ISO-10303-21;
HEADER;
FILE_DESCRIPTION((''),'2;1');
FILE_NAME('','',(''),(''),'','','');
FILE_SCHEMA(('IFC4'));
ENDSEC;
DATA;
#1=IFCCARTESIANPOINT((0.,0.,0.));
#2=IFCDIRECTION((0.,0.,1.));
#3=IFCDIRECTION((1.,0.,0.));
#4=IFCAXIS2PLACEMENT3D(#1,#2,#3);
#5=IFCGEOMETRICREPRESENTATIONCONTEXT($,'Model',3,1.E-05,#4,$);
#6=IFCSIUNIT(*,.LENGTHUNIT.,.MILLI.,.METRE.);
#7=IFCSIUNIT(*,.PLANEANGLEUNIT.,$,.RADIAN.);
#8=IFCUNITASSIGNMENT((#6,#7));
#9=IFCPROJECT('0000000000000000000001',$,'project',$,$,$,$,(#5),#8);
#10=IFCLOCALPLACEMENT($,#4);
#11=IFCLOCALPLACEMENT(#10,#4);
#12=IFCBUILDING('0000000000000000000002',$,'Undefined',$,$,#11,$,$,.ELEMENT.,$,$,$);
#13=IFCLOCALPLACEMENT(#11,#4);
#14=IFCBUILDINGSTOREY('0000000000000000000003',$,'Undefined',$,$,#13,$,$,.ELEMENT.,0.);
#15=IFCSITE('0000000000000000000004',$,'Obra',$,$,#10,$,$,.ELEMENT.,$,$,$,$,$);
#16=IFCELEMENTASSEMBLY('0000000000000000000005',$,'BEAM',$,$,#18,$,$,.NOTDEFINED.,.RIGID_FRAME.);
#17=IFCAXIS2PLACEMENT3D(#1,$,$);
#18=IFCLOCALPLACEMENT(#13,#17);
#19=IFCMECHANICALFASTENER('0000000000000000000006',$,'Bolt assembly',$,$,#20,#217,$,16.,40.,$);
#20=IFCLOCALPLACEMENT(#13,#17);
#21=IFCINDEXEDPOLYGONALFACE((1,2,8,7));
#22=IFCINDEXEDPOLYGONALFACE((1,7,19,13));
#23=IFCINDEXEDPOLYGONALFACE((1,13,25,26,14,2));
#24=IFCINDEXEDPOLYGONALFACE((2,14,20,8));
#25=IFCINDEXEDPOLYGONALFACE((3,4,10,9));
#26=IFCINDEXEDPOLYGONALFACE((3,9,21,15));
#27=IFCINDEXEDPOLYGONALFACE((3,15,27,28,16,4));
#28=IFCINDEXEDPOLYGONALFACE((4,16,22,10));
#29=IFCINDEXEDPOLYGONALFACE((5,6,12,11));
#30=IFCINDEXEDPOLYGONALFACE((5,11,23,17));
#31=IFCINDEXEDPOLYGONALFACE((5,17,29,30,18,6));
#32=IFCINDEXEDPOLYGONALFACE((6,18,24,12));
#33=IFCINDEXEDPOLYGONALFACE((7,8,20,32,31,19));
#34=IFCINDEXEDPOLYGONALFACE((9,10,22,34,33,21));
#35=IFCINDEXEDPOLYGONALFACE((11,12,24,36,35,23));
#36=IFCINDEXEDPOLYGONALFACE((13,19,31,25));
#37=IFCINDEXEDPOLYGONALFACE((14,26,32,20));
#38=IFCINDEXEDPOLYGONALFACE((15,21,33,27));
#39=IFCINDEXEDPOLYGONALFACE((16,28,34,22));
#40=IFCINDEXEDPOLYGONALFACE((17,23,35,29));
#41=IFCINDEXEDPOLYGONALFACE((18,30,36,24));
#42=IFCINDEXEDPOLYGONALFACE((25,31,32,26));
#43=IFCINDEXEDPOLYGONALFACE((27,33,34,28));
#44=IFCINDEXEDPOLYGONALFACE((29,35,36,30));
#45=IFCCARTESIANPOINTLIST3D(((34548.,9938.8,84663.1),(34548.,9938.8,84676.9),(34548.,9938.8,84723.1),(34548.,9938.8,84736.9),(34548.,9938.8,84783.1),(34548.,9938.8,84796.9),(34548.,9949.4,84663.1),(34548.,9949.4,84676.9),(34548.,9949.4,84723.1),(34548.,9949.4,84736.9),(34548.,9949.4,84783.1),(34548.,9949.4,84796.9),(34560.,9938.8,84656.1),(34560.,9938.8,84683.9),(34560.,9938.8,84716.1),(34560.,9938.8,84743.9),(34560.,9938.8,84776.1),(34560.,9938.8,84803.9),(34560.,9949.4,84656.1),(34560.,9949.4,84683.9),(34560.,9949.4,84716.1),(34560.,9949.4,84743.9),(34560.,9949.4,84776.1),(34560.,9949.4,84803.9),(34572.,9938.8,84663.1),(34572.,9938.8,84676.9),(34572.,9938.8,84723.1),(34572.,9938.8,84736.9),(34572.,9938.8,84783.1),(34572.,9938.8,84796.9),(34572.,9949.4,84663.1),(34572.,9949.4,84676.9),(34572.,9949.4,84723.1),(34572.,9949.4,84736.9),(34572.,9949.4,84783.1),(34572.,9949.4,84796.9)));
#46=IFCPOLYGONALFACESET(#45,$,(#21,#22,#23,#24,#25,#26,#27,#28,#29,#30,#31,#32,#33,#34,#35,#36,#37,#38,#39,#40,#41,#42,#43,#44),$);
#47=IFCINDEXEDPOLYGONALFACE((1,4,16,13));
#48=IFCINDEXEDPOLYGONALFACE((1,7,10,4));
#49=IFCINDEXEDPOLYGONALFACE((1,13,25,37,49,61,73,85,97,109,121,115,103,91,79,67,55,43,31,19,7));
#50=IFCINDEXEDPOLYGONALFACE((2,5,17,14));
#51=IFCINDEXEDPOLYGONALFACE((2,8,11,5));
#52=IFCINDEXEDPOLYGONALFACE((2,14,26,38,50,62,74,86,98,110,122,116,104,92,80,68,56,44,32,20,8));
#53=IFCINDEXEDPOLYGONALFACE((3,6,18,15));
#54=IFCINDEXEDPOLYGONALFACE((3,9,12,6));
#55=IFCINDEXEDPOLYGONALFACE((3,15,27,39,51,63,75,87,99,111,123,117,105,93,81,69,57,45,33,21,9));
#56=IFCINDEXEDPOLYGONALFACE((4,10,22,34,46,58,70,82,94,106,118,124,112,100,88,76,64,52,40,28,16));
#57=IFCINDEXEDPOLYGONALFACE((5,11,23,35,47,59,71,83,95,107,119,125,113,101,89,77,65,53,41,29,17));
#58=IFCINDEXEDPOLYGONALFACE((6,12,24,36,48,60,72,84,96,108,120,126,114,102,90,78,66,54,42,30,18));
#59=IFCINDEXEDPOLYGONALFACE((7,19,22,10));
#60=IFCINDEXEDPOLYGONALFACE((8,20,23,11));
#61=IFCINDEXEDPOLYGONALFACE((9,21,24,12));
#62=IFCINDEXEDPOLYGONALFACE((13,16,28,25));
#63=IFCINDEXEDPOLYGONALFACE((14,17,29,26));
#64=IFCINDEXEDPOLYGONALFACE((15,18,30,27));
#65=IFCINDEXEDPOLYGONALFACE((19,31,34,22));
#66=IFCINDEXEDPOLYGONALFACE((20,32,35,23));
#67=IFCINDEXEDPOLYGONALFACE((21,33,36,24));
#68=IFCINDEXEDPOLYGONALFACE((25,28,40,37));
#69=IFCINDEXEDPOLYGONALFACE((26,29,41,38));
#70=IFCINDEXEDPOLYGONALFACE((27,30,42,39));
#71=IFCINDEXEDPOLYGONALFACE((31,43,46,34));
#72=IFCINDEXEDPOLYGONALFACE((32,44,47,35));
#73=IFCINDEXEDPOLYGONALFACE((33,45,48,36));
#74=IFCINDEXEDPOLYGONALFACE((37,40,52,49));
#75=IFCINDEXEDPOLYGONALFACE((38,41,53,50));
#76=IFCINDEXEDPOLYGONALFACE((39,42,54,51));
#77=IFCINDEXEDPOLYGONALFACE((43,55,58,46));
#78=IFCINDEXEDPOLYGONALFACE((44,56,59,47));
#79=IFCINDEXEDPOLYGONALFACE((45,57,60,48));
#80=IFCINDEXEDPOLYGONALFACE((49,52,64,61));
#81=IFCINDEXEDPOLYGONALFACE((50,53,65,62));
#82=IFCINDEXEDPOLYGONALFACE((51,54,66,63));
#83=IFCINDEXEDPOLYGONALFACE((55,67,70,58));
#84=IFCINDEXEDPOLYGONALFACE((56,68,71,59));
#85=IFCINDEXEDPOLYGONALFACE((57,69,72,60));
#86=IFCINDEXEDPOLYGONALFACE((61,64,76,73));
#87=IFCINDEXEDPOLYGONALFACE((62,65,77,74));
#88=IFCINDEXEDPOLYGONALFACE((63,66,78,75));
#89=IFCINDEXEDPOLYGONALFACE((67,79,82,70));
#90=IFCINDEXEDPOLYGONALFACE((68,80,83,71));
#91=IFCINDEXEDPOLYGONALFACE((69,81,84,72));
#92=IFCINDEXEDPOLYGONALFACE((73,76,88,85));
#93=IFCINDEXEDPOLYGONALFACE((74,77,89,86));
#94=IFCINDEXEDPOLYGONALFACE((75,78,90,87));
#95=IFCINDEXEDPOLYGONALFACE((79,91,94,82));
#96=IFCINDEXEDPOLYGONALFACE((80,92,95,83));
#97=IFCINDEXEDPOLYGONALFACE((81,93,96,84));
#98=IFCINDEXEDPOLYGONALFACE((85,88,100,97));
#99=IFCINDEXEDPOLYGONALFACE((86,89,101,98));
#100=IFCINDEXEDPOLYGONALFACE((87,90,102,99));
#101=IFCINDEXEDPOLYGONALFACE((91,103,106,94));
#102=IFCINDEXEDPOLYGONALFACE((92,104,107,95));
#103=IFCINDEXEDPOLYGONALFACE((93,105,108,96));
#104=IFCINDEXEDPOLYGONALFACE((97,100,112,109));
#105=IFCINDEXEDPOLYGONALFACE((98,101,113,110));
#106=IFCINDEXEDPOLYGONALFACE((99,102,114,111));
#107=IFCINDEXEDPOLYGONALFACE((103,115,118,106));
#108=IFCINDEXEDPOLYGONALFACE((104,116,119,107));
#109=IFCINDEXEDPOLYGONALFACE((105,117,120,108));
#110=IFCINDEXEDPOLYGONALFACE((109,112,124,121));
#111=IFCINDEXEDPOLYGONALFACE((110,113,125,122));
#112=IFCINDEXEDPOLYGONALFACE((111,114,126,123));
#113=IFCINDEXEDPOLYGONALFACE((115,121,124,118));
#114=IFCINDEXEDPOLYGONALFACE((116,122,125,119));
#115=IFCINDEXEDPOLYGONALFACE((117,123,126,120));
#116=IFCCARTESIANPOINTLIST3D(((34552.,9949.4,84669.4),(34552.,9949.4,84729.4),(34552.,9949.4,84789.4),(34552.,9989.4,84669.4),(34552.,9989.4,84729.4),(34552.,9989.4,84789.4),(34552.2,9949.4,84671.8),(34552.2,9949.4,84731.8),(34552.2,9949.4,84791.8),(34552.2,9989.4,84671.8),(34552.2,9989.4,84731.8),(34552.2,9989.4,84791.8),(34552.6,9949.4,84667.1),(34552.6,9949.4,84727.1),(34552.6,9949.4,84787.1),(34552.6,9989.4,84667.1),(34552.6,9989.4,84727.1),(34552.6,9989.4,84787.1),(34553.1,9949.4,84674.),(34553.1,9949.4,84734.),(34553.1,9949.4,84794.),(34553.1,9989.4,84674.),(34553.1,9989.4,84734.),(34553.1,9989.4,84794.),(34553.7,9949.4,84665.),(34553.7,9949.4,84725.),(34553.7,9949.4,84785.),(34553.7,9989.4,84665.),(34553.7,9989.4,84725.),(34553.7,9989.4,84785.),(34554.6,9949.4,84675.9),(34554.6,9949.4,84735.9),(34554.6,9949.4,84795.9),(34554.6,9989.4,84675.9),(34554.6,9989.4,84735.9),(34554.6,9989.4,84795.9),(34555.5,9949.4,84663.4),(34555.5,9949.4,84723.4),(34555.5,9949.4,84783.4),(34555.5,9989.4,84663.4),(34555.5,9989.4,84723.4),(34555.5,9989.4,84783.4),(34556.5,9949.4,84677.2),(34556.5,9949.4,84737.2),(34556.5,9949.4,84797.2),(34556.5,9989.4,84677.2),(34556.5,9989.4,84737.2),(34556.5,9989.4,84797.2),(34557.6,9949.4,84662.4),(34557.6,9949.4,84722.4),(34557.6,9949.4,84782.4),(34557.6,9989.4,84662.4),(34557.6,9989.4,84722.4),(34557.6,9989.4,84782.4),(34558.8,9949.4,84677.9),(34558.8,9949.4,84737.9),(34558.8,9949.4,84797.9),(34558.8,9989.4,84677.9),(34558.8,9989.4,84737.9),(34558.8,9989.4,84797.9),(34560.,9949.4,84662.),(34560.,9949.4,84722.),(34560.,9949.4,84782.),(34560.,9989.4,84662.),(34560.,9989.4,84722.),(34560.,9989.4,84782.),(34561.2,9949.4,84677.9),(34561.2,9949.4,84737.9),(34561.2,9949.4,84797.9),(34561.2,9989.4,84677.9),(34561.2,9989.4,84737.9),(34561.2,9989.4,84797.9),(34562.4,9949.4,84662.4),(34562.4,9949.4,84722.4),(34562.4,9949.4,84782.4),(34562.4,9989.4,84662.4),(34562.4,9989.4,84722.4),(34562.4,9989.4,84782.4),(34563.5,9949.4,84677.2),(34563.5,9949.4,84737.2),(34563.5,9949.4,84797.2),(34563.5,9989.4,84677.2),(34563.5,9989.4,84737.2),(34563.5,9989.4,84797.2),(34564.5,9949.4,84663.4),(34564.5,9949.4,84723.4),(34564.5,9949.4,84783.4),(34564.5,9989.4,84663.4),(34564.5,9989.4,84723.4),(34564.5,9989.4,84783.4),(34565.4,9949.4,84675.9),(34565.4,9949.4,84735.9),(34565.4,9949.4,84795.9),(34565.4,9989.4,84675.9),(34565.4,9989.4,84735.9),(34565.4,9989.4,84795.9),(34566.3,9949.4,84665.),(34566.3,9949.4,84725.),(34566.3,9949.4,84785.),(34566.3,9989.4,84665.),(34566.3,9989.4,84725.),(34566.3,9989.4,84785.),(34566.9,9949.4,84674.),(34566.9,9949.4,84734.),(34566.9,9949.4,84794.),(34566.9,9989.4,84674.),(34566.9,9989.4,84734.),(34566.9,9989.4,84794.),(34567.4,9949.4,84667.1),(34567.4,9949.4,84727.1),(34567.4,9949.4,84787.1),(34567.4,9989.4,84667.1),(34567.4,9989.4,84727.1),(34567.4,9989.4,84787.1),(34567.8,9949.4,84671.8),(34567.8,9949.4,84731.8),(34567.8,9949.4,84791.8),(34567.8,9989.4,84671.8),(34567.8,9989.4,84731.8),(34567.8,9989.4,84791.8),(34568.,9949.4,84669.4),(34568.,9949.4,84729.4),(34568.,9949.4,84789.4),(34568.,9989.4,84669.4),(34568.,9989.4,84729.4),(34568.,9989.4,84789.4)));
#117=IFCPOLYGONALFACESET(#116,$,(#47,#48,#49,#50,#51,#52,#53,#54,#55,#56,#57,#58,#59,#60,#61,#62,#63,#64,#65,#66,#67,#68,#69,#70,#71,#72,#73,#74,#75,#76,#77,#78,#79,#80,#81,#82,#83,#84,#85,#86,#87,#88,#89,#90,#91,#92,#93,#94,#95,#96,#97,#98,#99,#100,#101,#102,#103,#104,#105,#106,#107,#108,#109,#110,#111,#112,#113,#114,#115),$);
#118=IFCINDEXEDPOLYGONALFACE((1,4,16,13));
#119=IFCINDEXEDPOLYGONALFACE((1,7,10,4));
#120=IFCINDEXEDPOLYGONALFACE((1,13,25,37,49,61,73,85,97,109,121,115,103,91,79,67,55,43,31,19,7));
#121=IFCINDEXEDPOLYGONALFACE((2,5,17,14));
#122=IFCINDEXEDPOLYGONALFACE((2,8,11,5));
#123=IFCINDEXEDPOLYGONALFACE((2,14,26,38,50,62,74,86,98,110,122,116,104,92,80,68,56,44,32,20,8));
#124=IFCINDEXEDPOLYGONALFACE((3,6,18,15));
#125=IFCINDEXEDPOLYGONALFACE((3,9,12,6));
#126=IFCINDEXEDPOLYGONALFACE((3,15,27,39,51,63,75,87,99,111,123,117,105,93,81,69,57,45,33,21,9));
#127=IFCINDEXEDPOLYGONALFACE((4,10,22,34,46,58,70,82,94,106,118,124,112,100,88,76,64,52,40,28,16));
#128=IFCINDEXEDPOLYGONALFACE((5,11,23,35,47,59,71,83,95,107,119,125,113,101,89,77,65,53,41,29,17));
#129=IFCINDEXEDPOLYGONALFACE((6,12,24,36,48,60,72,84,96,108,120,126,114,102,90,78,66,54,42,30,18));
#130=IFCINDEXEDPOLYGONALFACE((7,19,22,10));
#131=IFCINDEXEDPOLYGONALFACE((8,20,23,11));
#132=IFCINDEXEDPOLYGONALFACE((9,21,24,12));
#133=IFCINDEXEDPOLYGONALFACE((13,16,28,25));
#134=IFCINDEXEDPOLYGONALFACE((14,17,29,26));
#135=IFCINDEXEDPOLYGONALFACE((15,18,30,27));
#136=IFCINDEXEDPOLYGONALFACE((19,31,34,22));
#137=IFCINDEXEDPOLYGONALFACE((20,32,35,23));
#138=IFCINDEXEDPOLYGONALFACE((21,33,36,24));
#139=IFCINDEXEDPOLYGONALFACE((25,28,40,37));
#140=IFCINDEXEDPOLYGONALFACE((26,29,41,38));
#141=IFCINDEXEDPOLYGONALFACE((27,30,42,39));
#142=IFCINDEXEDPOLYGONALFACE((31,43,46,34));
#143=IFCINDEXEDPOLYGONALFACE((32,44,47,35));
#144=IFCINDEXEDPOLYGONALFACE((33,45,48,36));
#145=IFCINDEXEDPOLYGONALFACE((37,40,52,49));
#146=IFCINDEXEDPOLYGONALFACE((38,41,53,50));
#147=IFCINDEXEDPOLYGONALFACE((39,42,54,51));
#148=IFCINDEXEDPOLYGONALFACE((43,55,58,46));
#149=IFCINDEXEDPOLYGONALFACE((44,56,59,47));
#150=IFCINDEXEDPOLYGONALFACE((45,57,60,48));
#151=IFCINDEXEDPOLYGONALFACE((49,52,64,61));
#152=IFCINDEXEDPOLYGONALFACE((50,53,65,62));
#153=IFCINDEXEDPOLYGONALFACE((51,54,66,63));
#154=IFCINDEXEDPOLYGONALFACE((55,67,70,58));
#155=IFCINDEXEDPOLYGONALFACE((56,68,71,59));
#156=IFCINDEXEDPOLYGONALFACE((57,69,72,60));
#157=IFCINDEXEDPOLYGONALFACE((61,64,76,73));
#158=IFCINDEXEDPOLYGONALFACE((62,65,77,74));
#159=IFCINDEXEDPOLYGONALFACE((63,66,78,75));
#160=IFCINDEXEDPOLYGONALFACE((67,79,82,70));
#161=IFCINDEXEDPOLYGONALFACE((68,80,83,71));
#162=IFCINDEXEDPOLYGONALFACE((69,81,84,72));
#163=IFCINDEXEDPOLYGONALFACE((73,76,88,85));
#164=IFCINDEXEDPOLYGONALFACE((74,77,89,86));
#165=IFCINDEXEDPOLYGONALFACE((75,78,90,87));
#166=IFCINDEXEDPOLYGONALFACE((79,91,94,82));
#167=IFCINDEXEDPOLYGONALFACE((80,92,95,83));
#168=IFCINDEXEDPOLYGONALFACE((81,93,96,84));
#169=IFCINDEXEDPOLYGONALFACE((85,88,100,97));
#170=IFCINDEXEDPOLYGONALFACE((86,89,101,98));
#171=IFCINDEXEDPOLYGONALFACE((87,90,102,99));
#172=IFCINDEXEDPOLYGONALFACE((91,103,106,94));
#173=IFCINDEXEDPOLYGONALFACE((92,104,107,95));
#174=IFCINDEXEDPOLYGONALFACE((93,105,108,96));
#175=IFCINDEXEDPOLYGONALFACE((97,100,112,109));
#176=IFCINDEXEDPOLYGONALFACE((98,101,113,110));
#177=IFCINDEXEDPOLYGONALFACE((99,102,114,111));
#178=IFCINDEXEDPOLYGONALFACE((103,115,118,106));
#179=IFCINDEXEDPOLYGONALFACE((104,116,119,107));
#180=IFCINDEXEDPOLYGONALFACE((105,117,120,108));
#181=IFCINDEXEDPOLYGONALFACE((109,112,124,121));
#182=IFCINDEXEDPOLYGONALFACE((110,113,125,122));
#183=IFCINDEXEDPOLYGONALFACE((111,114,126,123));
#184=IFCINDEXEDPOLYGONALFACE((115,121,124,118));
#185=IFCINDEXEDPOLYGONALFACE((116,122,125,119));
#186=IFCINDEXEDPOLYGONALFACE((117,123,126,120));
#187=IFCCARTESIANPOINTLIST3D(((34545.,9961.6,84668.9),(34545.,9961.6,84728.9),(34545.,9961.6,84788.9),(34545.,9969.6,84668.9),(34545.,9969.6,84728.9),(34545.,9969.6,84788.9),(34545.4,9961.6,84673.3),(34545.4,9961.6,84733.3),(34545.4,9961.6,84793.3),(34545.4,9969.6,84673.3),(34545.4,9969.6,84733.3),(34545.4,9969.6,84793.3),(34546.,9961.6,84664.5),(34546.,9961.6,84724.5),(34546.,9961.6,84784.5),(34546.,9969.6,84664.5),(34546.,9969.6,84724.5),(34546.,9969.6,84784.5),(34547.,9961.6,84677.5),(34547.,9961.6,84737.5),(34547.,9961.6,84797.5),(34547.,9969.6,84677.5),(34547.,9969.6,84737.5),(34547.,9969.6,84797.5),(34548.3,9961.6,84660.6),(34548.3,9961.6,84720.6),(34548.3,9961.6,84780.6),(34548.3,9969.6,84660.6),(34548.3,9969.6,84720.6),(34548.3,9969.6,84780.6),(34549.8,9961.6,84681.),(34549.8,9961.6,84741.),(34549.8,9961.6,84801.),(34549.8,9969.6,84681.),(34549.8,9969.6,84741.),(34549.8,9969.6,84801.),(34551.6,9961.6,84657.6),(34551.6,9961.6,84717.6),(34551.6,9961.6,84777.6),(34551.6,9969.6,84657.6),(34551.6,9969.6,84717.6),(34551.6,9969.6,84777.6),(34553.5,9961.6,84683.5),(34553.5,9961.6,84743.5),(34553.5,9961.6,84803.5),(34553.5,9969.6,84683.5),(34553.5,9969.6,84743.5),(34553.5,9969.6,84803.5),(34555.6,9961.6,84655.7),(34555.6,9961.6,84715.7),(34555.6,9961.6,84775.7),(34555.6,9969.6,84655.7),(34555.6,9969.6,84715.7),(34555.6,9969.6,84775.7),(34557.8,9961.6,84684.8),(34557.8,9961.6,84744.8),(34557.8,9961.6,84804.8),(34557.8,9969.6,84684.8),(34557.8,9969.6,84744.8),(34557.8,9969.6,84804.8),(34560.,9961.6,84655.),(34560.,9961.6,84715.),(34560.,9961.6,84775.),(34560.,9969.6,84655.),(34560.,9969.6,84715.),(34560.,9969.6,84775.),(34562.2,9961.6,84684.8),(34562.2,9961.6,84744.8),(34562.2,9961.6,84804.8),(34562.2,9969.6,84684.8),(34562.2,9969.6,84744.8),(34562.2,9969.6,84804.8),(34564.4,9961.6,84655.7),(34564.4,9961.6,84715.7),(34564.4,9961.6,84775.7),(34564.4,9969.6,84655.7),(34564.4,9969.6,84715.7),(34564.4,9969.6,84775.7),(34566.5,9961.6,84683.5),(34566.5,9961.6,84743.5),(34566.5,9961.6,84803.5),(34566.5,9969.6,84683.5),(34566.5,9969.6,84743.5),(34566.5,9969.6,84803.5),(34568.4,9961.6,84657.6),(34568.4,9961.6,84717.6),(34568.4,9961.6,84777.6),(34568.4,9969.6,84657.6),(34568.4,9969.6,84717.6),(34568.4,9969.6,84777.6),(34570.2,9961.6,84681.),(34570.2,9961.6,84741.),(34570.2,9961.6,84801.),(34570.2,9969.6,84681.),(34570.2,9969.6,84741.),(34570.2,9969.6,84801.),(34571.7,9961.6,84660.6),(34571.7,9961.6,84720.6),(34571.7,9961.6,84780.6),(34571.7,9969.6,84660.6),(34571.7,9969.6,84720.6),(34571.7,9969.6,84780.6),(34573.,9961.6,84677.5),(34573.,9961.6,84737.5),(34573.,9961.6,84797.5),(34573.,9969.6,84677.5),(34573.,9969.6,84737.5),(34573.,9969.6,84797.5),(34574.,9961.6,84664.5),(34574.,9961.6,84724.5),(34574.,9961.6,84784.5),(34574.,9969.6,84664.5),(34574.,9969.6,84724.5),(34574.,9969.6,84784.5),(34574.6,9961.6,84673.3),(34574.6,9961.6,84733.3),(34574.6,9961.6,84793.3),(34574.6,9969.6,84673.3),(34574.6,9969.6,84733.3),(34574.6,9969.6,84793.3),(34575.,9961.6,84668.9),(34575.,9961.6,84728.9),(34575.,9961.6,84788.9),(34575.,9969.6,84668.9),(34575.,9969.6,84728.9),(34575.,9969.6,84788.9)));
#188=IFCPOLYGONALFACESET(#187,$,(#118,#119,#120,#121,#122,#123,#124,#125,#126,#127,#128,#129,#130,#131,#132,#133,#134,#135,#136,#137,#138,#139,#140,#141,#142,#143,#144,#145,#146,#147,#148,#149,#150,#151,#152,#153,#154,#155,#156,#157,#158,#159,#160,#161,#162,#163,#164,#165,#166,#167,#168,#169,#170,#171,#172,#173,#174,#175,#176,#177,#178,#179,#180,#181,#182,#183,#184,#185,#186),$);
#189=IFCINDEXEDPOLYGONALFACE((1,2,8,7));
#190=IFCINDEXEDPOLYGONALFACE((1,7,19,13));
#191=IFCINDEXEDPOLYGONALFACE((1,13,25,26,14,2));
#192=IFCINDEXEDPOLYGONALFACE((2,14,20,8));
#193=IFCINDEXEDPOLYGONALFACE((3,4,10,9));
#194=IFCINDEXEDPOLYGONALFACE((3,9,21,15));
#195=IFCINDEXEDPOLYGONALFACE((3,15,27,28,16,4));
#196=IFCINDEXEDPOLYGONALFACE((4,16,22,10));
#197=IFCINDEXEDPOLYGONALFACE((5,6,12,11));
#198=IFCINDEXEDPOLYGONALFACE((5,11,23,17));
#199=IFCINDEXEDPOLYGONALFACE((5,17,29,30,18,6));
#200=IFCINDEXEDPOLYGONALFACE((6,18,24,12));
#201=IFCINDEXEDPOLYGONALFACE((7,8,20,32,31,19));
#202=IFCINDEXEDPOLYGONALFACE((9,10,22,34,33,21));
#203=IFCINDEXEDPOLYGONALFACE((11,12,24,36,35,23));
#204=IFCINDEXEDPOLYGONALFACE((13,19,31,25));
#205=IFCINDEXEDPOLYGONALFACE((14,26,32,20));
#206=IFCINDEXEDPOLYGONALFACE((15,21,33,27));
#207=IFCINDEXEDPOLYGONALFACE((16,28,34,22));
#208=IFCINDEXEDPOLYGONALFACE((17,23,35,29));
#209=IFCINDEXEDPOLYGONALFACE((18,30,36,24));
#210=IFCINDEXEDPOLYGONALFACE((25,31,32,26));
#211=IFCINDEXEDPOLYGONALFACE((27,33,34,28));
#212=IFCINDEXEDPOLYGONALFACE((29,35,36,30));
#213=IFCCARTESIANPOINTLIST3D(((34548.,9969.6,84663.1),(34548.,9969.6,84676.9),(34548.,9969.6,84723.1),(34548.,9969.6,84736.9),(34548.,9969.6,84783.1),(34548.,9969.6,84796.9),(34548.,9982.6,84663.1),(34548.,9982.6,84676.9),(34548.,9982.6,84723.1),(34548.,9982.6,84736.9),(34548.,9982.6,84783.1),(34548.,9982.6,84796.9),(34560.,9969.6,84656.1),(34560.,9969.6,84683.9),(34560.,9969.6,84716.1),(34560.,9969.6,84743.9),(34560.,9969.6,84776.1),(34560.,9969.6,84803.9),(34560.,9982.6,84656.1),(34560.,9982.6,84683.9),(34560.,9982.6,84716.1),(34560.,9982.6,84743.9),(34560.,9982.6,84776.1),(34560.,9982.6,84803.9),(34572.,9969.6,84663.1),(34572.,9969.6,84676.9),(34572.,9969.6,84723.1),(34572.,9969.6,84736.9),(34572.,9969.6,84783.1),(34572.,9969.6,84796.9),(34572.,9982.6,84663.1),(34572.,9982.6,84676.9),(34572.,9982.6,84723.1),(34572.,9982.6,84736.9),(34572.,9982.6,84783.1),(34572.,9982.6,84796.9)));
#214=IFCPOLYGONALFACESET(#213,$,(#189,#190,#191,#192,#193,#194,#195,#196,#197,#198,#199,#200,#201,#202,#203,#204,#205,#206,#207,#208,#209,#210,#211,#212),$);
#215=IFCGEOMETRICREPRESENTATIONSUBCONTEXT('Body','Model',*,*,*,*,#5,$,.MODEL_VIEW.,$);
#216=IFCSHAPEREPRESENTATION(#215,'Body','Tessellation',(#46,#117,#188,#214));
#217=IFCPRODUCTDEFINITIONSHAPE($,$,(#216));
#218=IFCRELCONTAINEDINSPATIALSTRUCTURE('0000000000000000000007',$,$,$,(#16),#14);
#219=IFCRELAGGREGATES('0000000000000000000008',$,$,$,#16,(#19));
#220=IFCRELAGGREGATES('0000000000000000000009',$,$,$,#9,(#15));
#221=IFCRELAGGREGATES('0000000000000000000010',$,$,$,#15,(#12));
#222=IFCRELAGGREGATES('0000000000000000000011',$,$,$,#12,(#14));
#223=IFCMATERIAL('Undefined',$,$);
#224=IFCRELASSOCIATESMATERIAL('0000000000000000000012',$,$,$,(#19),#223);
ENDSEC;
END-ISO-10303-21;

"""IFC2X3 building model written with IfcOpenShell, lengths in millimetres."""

from ifc_helpers import new_model, si_unit, frame, origin_with_axes, origin_2d_with_axis, place, context, subcontext, project, spatial, polyline, circle, outline, extrude, source, transform, mapped, material, element, aggregate, save


model = new_model("IFC2X3")

# Units and contexts
model_context = context("Model", 3, precision=1e-05, world=origin_with_axes())
body_context = subcontext(model_context, "Body", "Model", "MODEL_VIEW")
ifc_project = project(units=[si_unit("LENGTHUNIT", "METRE", prefix="MILLI"), si_unit("PLANEANGLEUNIT", "RADIAN")], contexts=[model_context])

# Site, building, storey
site_placement = place(None, origin_with_axes())
site = spatial("IfcSite", under=ifc_project, at=site_placement, Name="Obra", CompositionType="ELEMENT")
building_placement = place(site_placement, origin_with_axes())
building = spatial("IfcBuilding", under=site, at=building_placement, Name="Undefined", CompositionType="ELEMENT")
storey_placement = place(building_placement, origin_with_axes())
storey = spatial("IfcBuildingStorey", under=building, at=storey_placement, Name="Undefined", CompositionType="ELEMENT", Elevation=0.0)

# Shared definitions
ifc_material_1 = material(Name="Undefined")

# Element assembly, mechanical fastener
assembly_1_placement = place(storey_placement, origin_with_axes())
assembly_1 = element("IfcElementAssembly", 1, at=assembly_1_placement, inside=storey, Name="BEAM", AssemblyPlace="NOTDEFINED", PredefinedType="RIGID_FRAME")
shared_shape_1 = source(origin_with_axes(), body_context, "Body", "SweptSolid", [
    extrude(outline(polyline([(13.9, 0.0), (6.9, 12.0), (-6.9, 12.0), (-13.9, 0.0), (-6.9, -12.0), (6.9, -12.0), (13.9, 0.0)])), frame((0.0, -19.7, 0.0), z_axis=(0.0, 1.0, 0.0), x_axis=(1.0, 0.0, 0.0)), (0.0, 0.0, 1.0), 10.6),
    extrude(circle(Radius=8.0, at=origin_2d_with_axis()), frame((0.0, -9.1, 0.0), z_axis=(0.0, 1.0, 0.0), x_axis=(1.0, 0.0, 0.0)), (0.0, 0.0, 1.0), 40.0),
    extrude(circle(Radius=15.0, at=origin_2d_with_axis()), frame((0.0, 3.1, 0.0), z_axis=(0.0, 1.0, 0.0), x_axis=(1.0, 0.0, 0.0)), (0.0, 0.0, 1.0), 8.0),
    extrude(outline(polyline([(13.9, 0.0), (6.9, 12.0), (-6.9, 12.0), (-13.9, 0.0), (-6.9, -12.0), (6.9, -12.0), (13.9, 0.0)])), frame((0.0, 11.1, 0.0), z_axis=(0.0, 1.0, 0.0), x_axis=(1.0, 0.0, 0.0)), (0.0, 0.0, 1.0), 13.0),
])
mechanical_fastener_1_placement = place(assembly_1_placement, frame((34510.0, 9958.5, 84850.0), z_axis=(1.0, 0.0, 0.0), x_axis=(0.0, 0.0, -1.0)))
mechanical_fastener_1 = element("IfcMechanicalFastener", 2, at=mechanical_fastener_1_placement, material=ifc_material_1, Name="Bolt assembly", NominalDiameter=16.0, NominalLength=40.0, context=body_context, shape_type="MappedRepresentation", body=[
    mapped(shared_shape_1, transform((60.0, 0.0, 50.0))),
    mapped(shared_shape_1, transform((120.0, 0.0, 50.0))),
    mapped(shared_shape_1, transform((180.0, 0.0, 50.0))),
])
aggregate(assembly_1, [mechanical_fastener_1])

save(model, "model.ifc")
